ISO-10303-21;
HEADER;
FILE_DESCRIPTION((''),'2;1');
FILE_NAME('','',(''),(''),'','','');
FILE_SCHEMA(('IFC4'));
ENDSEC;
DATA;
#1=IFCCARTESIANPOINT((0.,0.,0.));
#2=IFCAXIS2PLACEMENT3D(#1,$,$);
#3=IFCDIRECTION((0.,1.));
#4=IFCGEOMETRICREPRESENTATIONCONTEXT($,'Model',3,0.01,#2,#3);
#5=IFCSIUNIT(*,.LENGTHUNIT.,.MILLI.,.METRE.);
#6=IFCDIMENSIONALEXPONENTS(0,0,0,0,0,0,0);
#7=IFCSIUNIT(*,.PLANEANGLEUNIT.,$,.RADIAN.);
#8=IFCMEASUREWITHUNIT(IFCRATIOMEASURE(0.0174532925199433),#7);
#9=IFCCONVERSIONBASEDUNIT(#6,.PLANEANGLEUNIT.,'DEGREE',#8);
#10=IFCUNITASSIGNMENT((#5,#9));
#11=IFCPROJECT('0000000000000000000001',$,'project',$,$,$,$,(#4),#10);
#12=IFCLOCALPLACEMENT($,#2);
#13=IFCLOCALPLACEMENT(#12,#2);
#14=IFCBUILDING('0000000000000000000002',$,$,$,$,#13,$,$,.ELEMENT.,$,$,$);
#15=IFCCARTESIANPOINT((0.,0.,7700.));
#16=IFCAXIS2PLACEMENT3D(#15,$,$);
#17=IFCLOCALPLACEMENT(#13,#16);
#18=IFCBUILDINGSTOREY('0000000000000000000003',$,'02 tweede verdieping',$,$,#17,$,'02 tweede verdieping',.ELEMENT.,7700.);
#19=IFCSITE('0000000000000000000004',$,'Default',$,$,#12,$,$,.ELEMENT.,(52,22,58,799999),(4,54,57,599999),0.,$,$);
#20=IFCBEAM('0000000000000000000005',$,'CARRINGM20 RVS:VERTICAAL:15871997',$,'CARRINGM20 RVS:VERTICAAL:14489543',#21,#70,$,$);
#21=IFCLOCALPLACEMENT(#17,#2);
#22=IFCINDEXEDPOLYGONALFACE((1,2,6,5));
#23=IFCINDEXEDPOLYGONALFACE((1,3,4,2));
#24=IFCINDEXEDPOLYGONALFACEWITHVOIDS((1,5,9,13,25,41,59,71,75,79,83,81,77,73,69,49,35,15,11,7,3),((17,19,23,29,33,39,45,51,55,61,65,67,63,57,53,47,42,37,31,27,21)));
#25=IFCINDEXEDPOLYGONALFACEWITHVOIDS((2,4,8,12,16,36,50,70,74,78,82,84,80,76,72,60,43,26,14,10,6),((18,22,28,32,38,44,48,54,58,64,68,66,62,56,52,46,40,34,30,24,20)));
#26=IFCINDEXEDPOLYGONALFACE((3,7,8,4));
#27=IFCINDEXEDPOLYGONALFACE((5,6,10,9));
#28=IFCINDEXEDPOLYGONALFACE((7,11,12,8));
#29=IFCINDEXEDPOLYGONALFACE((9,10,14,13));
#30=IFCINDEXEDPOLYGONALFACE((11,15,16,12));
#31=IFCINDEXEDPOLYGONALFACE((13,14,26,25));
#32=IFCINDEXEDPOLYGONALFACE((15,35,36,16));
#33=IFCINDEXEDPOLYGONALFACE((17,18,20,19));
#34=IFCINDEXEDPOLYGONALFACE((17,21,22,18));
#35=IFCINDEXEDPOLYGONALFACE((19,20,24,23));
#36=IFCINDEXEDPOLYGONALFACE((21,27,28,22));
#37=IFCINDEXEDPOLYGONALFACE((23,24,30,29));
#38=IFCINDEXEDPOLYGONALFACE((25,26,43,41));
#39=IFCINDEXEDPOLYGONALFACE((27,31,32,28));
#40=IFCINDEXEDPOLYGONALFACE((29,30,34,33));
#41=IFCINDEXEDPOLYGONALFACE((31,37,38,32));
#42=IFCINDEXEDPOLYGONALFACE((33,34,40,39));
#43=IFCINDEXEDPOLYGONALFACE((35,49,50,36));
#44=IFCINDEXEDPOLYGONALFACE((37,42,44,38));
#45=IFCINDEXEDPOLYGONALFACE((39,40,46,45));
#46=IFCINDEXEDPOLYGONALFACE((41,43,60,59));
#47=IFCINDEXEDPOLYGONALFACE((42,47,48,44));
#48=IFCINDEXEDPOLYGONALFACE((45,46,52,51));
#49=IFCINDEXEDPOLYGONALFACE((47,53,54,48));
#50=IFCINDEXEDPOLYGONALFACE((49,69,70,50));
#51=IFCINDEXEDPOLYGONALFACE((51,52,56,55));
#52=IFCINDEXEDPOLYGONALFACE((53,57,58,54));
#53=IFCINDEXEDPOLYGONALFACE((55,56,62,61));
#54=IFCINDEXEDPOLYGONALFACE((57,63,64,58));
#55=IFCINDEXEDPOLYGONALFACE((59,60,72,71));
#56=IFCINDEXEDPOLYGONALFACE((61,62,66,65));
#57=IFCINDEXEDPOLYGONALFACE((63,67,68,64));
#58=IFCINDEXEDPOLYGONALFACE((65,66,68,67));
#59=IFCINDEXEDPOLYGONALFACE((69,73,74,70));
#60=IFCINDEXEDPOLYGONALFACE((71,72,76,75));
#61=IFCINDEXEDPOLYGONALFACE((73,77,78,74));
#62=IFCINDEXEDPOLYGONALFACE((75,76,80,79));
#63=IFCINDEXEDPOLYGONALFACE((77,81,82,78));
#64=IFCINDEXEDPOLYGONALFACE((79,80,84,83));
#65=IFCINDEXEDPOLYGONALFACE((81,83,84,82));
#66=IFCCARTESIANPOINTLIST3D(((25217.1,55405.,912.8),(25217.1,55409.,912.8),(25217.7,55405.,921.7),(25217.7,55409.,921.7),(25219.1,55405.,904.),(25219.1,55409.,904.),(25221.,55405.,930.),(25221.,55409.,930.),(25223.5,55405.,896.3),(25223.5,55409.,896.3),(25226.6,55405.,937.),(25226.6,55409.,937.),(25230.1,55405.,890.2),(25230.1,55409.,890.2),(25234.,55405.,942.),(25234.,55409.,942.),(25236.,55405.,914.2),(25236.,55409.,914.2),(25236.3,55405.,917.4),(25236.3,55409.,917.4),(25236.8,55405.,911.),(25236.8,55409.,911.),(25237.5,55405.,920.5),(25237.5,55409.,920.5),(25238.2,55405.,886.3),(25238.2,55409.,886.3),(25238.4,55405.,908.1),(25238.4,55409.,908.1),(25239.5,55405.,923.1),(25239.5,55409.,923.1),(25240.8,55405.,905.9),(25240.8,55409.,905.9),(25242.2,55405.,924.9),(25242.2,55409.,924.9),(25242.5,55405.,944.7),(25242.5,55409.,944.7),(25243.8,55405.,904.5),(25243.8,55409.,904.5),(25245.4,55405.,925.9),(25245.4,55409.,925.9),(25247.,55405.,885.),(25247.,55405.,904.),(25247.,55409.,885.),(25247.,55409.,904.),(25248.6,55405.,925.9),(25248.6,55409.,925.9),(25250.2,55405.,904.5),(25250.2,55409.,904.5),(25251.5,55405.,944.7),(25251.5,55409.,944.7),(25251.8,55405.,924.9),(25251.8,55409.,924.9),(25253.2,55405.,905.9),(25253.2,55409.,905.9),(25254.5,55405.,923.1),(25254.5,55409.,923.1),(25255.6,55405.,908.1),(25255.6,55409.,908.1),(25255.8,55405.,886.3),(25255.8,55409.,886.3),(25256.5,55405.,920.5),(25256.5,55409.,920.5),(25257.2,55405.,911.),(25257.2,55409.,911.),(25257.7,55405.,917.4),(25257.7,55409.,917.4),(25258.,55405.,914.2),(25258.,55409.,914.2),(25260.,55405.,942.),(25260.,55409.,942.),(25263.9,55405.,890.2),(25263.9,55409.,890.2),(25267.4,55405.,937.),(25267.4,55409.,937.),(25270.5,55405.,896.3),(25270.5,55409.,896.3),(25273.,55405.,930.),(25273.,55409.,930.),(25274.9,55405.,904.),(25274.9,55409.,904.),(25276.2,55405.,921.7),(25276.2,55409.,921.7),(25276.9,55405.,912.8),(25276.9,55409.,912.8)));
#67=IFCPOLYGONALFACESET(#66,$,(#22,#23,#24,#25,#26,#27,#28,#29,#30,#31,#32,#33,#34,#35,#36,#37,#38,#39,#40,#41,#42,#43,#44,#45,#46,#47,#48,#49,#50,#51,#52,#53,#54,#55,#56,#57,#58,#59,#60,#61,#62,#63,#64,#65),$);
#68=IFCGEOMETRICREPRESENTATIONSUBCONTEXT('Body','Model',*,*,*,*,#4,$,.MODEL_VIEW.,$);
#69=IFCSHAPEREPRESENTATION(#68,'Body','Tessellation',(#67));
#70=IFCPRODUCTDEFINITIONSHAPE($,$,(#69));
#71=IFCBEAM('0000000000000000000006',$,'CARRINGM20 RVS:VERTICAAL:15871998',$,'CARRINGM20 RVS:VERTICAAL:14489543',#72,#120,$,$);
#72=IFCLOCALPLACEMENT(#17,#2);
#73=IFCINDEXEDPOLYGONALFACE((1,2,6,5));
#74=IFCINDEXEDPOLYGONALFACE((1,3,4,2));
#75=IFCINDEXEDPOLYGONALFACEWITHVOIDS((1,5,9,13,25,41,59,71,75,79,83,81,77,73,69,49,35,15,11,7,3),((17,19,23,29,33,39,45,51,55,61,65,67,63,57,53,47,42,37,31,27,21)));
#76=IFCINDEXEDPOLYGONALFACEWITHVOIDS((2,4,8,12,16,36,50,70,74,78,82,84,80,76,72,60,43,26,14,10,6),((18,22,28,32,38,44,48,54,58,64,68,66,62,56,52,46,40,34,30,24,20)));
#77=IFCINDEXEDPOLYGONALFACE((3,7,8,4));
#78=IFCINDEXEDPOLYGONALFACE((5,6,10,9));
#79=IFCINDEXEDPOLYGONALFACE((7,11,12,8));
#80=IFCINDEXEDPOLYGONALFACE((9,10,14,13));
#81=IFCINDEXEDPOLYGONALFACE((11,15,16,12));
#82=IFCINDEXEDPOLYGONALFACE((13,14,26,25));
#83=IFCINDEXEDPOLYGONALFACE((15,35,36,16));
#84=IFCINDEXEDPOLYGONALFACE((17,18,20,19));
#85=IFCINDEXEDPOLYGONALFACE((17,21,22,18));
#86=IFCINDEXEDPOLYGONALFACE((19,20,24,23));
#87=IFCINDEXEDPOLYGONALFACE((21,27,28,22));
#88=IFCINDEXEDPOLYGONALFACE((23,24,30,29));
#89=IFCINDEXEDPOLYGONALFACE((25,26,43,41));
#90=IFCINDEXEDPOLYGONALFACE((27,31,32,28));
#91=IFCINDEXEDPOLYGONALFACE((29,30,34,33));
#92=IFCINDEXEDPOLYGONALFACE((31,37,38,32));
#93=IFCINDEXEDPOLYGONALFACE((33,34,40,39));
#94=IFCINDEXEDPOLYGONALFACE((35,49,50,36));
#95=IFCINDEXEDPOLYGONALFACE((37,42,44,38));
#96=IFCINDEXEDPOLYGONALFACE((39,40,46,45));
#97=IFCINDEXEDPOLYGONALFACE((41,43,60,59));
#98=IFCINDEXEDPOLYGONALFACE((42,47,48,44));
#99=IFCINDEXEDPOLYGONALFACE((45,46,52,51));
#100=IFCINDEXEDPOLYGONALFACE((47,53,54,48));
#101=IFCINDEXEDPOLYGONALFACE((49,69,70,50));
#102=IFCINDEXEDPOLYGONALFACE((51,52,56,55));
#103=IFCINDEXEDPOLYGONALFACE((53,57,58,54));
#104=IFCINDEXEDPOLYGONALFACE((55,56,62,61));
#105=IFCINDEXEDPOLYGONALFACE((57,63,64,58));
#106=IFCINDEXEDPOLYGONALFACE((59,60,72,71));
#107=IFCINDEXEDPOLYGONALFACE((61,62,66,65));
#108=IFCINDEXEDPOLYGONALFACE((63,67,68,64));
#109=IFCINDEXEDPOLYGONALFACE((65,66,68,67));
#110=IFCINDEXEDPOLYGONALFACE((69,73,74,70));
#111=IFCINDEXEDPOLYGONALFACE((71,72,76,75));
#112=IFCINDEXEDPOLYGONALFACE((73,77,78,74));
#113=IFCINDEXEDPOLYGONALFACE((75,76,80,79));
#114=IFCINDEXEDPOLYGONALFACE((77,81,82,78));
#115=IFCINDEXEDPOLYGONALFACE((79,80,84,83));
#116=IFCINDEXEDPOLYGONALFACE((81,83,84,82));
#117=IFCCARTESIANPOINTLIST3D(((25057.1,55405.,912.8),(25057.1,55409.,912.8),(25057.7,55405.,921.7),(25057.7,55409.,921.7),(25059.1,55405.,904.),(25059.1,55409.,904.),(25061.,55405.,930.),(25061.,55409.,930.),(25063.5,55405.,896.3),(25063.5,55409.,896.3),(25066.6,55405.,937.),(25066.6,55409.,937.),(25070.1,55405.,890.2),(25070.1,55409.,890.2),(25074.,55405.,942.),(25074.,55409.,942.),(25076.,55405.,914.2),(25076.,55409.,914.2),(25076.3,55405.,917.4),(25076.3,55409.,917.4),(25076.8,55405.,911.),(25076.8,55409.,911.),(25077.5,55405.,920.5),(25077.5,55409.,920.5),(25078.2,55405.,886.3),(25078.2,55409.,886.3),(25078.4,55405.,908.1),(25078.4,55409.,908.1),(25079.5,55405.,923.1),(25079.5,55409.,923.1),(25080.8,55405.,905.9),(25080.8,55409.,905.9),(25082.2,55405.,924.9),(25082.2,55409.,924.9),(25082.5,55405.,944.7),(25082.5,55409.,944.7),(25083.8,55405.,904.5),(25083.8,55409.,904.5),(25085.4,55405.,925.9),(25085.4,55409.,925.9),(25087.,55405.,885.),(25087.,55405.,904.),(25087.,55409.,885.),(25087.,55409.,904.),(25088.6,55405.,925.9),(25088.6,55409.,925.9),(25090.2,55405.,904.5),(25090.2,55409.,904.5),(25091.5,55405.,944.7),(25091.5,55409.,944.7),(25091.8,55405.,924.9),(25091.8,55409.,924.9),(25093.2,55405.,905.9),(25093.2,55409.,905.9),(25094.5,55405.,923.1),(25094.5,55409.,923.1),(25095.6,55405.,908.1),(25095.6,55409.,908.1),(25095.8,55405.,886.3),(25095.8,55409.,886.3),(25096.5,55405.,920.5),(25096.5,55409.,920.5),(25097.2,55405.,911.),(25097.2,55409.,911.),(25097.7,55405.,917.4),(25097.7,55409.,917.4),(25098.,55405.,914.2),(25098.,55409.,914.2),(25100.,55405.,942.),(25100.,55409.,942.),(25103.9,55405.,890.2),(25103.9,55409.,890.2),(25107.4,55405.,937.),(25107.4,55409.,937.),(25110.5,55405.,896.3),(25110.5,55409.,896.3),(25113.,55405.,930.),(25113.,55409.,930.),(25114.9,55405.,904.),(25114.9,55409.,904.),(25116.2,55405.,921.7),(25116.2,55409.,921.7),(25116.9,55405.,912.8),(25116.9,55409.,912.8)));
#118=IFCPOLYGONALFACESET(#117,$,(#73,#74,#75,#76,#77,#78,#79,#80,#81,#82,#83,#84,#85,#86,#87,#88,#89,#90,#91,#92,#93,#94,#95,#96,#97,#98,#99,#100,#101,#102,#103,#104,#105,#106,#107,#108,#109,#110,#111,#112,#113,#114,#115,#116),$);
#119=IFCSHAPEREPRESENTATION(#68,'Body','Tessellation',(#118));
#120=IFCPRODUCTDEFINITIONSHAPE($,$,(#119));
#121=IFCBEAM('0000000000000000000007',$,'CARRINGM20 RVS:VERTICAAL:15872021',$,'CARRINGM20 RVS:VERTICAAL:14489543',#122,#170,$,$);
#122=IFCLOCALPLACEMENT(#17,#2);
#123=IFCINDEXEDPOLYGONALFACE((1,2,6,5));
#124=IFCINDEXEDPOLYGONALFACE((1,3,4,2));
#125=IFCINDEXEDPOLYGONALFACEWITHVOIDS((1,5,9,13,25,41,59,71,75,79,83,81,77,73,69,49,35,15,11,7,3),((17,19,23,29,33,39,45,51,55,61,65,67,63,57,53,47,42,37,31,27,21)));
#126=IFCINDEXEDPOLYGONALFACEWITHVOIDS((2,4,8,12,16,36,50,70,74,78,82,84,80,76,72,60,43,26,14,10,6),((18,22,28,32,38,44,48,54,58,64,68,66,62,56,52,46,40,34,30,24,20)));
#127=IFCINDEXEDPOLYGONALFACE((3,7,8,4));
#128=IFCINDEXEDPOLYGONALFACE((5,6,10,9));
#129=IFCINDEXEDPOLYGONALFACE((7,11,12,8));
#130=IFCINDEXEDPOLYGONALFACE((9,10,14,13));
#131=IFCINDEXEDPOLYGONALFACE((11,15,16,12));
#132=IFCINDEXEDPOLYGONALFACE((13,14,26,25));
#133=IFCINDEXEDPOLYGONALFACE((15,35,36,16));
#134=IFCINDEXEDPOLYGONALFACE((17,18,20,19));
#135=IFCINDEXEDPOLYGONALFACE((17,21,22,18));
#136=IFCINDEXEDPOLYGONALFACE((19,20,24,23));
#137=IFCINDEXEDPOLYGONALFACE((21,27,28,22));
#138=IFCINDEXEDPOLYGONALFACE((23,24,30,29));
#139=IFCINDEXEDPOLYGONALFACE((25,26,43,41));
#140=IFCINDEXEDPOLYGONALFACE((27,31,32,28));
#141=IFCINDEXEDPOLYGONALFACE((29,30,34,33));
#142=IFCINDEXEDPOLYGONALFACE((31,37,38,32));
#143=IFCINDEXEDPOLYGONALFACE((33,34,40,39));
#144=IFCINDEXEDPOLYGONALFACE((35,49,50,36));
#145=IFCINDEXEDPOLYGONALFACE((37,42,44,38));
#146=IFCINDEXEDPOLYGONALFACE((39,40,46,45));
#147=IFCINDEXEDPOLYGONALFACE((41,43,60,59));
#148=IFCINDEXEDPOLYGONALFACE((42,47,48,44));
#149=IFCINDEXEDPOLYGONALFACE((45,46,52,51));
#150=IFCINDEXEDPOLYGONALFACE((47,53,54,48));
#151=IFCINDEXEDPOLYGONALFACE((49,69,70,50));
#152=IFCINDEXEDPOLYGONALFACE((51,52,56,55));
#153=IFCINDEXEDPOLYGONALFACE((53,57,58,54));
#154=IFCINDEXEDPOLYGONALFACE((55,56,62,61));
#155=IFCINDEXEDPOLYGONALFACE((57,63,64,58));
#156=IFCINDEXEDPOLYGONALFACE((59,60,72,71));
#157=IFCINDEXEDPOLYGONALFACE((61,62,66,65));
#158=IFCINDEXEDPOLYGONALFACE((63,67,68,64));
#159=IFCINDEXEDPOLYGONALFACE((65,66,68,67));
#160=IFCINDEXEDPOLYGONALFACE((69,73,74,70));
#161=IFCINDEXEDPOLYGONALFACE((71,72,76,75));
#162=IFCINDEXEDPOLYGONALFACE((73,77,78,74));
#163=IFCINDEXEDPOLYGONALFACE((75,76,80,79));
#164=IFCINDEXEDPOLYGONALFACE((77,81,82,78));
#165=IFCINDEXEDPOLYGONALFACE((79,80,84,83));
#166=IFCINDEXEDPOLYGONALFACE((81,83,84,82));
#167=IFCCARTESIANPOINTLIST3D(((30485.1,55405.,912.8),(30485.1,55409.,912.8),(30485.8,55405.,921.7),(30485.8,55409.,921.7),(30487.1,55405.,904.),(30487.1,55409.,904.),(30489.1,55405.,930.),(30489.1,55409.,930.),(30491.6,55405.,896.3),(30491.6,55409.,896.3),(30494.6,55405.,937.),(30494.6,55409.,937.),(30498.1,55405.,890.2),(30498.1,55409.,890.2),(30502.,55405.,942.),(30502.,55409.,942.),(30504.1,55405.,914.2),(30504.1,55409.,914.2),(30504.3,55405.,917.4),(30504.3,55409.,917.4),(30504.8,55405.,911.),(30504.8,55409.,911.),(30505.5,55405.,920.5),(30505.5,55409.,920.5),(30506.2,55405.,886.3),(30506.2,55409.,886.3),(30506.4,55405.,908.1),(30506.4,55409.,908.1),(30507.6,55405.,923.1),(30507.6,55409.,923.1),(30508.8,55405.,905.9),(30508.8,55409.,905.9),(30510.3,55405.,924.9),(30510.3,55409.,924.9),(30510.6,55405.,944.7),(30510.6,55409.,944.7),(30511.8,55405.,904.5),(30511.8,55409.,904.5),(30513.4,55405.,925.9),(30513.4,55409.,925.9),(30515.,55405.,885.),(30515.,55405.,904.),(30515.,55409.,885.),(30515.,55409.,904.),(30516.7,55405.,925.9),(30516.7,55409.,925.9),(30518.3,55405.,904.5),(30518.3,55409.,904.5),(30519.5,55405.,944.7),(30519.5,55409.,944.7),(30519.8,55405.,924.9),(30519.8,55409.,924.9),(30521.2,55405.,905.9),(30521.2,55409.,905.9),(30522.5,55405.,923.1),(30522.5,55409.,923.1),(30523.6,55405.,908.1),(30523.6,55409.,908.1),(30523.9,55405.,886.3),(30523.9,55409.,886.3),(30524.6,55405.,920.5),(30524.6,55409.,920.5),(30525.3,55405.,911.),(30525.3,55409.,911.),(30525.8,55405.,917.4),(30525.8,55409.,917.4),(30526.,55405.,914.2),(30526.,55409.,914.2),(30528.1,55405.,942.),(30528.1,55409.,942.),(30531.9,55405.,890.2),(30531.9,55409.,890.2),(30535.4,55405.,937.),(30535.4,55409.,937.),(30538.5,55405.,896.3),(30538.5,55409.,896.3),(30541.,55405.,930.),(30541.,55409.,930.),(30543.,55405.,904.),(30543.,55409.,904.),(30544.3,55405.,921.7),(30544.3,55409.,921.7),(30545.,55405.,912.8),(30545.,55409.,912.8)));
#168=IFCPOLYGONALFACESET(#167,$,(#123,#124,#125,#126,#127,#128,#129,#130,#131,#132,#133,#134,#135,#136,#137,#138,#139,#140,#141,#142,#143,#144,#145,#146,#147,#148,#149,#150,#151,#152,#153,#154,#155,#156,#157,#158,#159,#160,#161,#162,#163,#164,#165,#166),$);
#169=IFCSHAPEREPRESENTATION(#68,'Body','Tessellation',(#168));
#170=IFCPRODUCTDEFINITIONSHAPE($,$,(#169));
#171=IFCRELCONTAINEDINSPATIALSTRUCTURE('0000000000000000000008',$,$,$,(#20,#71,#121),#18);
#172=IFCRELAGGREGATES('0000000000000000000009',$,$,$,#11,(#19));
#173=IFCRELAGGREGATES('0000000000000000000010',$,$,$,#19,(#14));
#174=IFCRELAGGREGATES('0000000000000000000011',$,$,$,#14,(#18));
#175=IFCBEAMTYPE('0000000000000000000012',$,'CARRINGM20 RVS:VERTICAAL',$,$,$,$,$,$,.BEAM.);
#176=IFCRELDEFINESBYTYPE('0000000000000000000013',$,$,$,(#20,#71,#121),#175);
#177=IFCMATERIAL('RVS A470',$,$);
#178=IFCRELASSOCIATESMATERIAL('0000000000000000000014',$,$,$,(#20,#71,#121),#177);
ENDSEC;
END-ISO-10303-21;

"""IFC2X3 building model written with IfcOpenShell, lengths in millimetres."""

from ifc_helpers import new_model, entity, si_unit, converted_unit, direction, frame, origin, origin_2d_with_axis, place, context, subcontext, project, spatial, hollow_circle, extrude, material, type_object, element, save


model = new_model("IFC2X3")

# Units and contexts
model_context = context("Model", 3, precision=0.01, world=origin(), true_north=direction((0.0, 1.0)))
body_context = subcontext(model_context, "Body", "Model", "MODEL_VIEW")
ifc_project = project(units=[si_unit("LENGTHUNIT", "METRE", prefix="MILLI"), converted_unit("PLANEANGLEUNIT", "DEGREE", entity("IfcRatioMeasure", 0.0174532925199433), si_unit("PLANEANGLEUNIT", "RADIAN"), dimensions=[0, 0, 0, 0, 0, 0, 0])], contexts=[model_context])

# Site, building, storey
site_placement = place(None, origin())
site = spatial("IfcSite", under=ifc_project, at=site_placement, Name="Default", CompositionType="ELEMENT", RefLatitude=(52, 22, 58, 799999), RefLongitude=(4, 54, 57, 599999), RefElevation=0.0)
building_placement = place(site_placement, origin())
building = spatial("IfcBuilding", under=site, at=building_placement, CompositionType="ELEMENT")
storey_placement = place(building_placement, frame((0.0, 0.0, 7700.0)))
storey = spatial("IfcBuildingStorey", under=building, at=storey_placement, Name="02 tweede verdieping", LongName="02 tweede verdieping", CompositionType="ELEMENT", Elevation=7700.0)

# Beams
ifc_material_1 = material(Name="RVS A470")
beam_type_1 = type_object("IfcBeamType", Name="CARRINGM20 RVS:VERTICAAL", PredefinedType="BEAM")
beam_1_placement = place(storey_placement, origin())
element("IfcBeam", 1, at=beam_1_placement, inside=storey, type_object=beam_type_1, material=ifc_material_1, Name="CARRINGM20 RVS:VERTICAAL:15871997", ObjectType="CARRINGM20 RVS:VERTICAAL:14489543", context=body_context, shape_type="SweptSolid", body=[
    extrude(hollow_circle(Radius=30.0, WallThickness=19.0, at=origin_2d_with_axis()), frame((25247.0, 55405.0, 915.0), z_axis=(0.0, 1.0, 0.0), x_axis=(0.0, 0.0, -1.0)), (0.0, 0.0, 1.0), 4.0),
])
beam_2_placement = place(storey_placement, origin())
element("IfcBeam", 2, at=beam_2_placement, inside=storey, type_object=beam_type_1, material=ifc_material_1, Name="CARRINGM20 RVS:VERTICAAL:15871998", ObjectType="CARRINGM20 RVS:VERTICAAL:14489543", context=body_context, shape_type="SweptSolid", body=[
    extrude(hollow_circle(Radius=30.0, WallThickness=19.0, at=origin_2d_with_axis()), frame((25087.0, 55405.0, 915.0), z_axis=(0.0, 1.0, 0.0), x_axis=(0.0, 0.0, -1.0)), (0.0, 0.0, 1.0), 4.0),
])
beam_3_placement = place(storey_placement, origin())
element("IfcBeam", 3, at=beam_3_placement, inside=storey, type_object=beam_type_1, material=ifc_material_1, Name="CARRINGM20 RVS:VERTICAAL:15872021", ObjectType="CARRINGM20 RVS:VERTICAAL:14489543", context=body_context, shape_type="SweptSolid", body=[
    extrude(hollow_circle(Radius=30.0, WallThickness=19.0, at=origin_2d_with_axis()), frame((30515.0, 55405.0, 915.0), z_axis=(0.0, 1.0, 0.0), x_axis=(0.0, 0.0, -1.0)), (0.0, 0.0, 1.0), 4.0),
])

save(model, "model.ifc")
